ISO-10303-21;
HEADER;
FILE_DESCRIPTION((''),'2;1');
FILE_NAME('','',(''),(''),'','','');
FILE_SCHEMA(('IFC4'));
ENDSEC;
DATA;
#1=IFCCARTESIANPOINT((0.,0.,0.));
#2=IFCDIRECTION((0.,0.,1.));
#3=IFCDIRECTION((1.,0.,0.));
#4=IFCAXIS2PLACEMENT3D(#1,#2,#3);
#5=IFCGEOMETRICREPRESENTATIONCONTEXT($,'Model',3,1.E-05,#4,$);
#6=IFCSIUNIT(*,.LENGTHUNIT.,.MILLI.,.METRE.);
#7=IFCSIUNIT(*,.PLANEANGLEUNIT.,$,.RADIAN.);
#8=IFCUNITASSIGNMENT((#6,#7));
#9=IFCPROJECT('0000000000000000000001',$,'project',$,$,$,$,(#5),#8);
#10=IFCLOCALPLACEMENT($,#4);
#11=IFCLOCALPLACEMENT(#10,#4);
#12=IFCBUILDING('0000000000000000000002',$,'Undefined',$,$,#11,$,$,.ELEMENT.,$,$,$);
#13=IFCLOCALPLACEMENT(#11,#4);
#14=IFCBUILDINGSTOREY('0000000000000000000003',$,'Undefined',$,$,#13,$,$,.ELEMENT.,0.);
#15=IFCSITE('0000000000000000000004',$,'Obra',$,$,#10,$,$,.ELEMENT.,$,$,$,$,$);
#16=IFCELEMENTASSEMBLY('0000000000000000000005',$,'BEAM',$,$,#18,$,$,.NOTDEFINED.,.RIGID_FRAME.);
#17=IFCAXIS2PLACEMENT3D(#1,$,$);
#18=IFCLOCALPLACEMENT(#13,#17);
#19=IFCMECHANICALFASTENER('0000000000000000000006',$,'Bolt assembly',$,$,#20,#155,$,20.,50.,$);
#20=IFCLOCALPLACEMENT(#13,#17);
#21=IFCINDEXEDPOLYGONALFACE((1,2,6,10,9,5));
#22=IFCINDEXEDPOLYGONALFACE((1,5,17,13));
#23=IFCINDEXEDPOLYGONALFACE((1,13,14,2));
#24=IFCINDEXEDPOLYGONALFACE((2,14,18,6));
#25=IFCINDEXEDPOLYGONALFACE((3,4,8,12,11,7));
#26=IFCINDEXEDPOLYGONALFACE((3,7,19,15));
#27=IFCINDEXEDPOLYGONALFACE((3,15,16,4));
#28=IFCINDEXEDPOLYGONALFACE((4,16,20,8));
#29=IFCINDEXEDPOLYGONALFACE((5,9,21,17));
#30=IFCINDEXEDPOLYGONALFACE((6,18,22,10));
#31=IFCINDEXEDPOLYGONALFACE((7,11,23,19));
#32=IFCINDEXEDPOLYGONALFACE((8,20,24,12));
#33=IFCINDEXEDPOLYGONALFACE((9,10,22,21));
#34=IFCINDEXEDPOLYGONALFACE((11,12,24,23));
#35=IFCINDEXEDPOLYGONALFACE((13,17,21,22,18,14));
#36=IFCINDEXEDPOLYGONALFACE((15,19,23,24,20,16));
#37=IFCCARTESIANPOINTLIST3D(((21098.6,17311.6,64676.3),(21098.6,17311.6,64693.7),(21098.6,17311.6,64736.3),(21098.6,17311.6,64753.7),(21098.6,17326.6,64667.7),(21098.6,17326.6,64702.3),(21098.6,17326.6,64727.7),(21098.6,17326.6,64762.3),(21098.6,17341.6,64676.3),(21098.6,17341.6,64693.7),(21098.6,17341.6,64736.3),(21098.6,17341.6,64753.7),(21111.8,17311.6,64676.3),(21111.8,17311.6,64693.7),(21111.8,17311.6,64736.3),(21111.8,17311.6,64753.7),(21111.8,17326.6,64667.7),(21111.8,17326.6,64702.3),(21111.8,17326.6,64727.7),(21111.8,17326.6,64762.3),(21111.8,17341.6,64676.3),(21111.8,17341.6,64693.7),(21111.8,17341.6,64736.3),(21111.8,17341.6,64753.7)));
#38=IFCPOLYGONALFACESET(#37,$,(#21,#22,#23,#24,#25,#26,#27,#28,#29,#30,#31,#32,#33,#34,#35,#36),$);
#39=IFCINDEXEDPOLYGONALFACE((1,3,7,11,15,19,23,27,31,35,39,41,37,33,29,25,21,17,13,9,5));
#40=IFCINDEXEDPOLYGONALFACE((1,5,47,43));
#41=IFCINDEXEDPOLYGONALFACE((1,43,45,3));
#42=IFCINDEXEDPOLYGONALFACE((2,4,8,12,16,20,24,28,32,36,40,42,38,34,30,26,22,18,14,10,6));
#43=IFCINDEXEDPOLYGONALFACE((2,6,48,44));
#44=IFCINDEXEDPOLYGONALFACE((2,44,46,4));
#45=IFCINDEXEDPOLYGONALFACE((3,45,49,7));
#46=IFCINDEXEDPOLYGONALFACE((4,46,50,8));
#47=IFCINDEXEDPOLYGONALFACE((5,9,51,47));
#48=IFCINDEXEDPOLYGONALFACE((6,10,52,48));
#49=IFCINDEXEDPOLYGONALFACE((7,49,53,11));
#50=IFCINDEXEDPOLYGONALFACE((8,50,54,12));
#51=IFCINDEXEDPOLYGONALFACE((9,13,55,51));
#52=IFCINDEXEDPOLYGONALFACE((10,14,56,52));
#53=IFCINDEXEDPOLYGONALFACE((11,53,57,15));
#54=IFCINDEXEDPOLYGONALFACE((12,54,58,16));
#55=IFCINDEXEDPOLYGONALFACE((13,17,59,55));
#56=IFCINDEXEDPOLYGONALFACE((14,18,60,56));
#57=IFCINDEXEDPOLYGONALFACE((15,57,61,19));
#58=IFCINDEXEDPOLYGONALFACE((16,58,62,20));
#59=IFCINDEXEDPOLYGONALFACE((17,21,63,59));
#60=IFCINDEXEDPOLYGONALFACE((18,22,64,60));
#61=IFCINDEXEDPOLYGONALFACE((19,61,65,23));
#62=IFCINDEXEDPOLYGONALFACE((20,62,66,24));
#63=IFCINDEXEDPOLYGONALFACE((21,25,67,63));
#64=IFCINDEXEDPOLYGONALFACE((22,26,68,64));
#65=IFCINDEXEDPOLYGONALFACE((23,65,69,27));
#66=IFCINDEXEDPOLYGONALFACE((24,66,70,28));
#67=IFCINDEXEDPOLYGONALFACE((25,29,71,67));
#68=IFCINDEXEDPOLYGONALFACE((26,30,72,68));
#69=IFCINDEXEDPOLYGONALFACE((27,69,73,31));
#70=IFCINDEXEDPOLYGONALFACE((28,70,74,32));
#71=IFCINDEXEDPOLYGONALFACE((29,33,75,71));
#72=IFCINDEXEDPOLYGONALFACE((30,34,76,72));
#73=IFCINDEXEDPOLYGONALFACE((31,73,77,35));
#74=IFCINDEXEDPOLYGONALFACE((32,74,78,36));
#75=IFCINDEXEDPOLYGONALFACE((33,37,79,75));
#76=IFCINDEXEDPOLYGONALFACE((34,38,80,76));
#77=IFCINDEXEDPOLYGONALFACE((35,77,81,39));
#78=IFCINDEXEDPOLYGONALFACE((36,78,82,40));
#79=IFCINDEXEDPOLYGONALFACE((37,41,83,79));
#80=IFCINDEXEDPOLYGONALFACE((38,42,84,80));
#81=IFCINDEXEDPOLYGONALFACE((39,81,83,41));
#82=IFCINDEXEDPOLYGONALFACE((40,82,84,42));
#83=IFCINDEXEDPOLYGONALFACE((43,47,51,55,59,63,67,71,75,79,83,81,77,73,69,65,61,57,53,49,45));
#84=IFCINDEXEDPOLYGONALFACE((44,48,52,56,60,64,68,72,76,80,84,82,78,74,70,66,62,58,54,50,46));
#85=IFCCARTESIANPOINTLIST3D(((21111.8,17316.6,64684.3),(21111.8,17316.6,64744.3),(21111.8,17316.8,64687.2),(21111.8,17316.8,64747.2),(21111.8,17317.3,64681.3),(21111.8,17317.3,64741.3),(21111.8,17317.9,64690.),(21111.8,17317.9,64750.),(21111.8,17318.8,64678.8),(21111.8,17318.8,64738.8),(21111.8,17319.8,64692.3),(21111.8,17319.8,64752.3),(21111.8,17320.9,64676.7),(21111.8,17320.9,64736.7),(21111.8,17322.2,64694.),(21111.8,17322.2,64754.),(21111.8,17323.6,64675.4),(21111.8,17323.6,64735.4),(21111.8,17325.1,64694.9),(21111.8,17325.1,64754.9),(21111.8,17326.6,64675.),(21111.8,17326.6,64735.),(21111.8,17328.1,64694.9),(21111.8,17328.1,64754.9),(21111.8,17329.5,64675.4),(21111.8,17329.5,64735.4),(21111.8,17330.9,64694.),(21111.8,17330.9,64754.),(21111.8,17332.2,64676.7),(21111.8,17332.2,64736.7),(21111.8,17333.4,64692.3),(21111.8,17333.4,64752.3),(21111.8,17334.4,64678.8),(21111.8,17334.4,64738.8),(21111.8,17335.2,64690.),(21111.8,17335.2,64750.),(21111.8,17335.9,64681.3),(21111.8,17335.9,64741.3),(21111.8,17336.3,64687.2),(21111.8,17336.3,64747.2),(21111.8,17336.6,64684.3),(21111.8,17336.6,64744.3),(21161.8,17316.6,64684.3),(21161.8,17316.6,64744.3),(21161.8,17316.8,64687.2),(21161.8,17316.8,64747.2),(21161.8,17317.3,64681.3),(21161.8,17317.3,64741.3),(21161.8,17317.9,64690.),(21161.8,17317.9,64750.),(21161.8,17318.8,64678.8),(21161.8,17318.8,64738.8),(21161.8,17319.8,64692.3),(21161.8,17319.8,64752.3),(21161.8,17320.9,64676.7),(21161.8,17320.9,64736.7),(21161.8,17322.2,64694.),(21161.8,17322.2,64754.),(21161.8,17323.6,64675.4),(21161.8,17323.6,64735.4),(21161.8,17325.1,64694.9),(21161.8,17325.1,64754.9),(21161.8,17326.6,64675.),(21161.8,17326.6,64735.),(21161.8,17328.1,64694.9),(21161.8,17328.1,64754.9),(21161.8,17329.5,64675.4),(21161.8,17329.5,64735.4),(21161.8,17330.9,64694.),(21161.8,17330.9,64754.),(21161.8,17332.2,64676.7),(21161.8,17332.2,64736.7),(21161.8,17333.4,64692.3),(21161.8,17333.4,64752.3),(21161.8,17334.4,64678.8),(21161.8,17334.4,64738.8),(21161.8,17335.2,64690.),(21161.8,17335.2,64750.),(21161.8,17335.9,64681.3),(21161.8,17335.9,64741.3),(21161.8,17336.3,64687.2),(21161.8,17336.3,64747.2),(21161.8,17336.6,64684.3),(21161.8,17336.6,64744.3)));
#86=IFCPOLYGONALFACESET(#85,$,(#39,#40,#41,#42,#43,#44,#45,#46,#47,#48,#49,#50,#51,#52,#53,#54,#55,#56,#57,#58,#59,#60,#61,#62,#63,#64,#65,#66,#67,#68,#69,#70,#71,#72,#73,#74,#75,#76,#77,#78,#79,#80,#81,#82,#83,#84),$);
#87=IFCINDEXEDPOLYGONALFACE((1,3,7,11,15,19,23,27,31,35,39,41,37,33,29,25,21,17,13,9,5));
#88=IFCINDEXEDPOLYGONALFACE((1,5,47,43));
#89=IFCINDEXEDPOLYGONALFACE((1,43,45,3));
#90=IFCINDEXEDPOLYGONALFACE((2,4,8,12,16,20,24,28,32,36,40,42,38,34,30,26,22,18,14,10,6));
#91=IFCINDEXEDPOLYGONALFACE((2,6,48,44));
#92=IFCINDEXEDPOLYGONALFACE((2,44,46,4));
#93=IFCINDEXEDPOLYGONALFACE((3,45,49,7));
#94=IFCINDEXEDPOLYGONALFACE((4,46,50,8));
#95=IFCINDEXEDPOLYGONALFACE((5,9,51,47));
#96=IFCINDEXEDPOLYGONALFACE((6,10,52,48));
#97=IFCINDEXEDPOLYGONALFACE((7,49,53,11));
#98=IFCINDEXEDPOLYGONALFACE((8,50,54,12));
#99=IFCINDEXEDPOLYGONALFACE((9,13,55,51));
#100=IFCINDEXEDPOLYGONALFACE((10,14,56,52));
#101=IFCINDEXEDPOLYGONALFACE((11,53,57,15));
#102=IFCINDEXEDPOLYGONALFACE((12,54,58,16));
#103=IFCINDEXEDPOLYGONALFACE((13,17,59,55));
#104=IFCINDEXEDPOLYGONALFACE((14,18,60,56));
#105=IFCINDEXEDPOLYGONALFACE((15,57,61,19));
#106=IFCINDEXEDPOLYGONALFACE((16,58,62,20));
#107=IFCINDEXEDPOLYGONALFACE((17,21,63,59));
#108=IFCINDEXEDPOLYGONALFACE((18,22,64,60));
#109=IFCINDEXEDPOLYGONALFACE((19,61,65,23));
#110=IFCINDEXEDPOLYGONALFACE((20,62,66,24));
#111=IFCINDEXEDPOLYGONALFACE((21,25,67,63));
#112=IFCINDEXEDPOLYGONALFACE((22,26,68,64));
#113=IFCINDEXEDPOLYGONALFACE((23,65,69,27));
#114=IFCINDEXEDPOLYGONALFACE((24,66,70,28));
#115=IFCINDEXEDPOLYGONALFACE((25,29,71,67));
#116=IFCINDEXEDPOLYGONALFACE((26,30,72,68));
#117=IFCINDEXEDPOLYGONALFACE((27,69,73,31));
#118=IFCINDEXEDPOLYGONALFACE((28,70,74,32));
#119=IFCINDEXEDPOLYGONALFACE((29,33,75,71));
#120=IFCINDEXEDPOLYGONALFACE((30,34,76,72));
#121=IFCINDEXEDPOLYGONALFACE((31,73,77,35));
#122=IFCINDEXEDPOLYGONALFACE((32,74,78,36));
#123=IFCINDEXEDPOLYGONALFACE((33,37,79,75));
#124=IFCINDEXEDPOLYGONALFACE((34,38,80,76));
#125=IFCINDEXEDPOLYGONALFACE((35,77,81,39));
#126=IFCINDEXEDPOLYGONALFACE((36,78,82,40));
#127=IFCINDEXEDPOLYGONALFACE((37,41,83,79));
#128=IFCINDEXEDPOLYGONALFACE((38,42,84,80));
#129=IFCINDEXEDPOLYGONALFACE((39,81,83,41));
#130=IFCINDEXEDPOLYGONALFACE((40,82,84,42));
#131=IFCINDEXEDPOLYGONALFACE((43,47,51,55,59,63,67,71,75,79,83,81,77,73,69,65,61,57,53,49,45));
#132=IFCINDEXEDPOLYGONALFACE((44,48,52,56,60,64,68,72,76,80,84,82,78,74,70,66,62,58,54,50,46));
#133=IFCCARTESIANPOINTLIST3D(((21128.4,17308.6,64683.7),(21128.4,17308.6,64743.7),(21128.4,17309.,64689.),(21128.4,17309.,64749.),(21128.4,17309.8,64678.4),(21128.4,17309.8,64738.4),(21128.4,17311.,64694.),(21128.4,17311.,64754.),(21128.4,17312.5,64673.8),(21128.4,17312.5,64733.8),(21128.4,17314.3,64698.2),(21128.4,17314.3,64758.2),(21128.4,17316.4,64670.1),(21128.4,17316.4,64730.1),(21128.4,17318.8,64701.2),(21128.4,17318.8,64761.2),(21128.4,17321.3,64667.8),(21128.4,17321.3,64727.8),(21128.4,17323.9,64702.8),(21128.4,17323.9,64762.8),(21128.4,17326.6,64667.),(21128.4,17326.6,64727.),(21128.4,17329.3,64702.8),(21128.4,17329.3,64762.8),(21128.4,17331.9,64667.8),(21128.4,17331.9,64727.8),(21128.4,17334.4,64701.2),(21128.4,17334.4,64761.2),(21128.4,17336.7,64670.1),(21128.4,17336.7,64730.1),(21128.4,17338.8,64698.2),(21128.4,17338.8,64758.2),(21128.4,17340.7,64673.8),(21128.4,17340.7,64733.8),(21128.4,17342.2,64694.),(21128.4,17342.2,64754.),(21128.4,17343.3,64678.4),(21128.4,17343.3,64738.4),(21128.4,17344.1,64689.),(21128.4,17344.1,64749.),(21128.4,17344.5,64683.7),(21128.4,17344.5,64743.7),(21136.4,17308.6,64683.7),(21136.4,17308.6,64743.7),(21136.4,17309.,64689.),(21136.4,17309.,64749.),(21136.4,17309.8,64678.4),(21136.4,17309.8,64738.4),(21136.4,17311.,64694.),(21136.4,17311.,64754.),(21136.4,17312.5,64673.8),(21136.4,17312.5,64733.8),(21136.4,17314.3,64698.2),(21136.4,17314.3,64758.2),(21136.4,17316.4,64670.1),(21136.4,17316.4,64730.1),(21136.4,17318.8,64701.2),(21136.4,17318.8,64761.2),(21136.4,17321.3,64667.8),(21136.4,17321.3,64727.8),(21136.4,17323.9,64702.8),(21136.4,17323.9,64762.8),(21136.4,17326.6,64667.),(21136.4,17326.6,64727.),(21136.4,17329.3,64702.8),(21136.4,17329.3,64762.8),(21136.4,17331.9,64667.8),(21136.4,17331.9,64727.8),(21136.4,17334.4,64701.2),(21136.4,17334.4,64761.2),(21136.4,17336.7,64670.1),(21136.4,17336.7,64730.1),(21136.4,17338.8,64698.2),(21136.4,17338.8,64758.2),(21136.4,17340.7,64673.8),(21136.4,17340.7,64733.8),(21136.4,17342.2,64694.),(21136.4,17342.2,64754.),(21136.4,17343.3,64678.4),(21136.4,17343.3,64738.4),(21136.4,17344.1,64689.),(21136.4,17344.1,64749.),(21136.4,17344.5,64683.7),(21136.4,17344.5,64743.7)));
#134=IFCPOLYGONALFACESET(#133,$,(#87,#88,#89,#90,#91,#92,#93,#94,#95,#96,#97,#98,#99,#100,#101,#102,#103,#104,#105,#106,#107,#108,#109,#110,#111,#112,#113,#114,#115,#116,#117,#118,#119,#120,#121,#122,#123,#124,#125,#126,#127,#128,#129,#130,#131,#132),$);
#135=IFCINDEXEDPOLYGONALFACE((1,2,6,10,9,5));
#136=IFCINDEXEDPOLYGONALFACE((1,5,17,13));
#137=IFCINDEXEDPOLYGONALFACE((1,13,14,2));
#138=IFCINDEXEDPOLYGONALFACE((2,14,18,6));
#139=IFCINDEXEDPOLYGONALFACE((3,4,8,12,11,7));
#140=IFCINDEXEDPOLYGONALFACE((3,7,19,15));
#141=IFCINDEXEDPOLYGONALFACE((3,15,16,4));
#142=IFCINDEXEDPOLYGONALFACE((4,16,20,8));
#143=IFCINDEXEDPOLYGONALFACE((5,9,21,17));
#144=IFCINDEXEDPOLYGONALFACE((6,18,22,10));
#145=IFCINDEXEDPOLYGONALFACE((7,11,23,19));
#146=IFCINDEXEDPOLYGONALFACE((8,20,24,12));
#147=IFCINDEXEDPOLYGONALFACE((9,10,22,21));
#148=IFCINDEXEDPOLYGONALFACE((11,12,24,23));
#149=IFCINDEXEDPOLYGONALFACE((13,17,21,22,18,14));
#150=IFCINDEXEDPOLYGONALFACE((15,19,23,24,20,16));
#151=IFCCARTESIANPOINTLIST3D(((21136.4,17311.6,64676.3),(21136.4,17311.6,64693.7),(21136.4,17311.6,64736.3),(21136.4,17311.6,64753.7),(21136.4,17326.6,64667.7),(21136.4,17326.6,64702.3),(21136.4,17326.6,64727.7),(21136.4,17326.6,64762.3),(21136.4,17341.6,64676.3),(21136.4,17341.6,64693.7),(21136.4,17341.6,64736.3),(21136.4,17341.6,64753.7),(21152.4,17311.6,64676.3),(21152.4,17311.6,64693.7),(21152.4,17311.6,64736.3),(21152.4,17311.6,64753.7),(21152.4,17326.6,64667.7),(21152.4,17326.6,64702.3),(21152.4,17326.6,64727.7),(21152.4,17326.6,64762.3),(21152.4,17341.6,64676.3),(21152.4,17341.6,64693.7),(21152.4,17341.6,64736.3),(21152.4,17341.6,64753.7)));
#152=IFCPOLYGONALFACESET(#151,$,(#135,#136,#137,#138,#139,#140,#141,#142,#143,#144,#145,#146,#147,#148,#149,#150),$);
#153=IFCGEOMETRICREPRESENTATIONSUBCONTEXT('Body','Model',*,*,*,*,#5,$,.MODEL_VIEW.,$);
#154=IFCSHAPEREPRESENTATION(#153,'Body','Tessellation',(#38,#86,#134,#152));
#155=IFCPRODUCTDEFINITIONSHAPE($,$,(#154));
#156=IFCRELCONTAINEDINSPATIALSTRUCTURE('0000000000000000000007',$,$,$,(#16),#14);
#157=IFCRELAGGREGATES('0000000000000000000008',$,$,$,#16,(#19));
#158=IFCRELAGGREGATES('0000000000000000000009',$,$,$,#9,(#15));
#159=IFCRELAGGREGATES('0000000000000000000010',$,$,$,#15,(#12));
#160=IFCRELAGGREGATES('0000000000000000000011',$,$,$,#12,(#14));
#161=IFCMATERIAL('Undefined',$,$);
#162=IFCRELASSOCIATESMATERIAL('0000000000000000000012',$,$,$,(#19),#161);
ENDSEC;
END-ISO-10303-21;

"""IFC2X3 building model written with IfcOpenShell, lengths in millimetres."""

from ifc_helpers import new_model, si_unit, frame, origin_with_axes, origin_2d_with_axis, place, context, subcontext, project, spatial, polyline, circle, outline, extrude, source, transform, mapped, material, element, aggregate, save


model = new_model("IFC2X3")

# Units and contexts
model_context = context("Model", 3, precision=1e-05, world=origin_with_axes())
body_context = subcontext(model_context, "Body", "Model", "MODEL_VIEW")
ifc_project = project(units=[si_unit("LENGTHUNIT", "METRE", prefix="MILLI"), si_unit("PLANEANGLEUNIT", "RADIAN")], contexts=[model_context])

# Site, building, storey
site_placement = place(None, origin_with_axes())
site = spatial("IfcSite", under=ifc_project, at=site_placement, Name="Obra", CompositionType="ELEMENT")
building_placement = place(site_placement, origin_with_axes())
building = spatial("IfcBuilding", under=site, at=building_placement, Name="Undefined", CompositionType="ELEMENT")
storey_placement = place(building_placement, origin_with_axes())
storey = spatial("IfcBuildingStorey", under=building, at=storey_placement, Name="Undefined", CompositionType="ELEMENT", Elevation=0.0)

# Shared definitions
ifc_material = material(Name="Undefined")
shared_shape_1 = source(origin_with_axes(), body_context, "Body", "SweptSolid", [
    extrude(outline(polyline([(17.3, 0.0), (8.7, 15.0), (-8.7, 15.0), (-17.3, 0.0), (-8.7, -15.0), (8.7, -15.0), (17.3, 0.0)])), frame((0.0, -26.5, 0.0), z_axis=(0.0, 1.0, 0.0), x_axis=(1.0, 0.0, 0.0)), (0.0, 0.0, 1.0), 13.2),
    extrude(circle(Radius=10.0, at=origin_2d_with_axis()), frame((0.0, -13.3, 0.0), z_axis=(0.0, 1.0, 0.0), x_axis=(1.0, 0.0, 0.0)), (0.0, 0.0, 1.0), 50.0),
    extrude(circle(Radius=18.0, at=origin_2d_with_axis()), frame((0.0, 3.3, 0.0), z_axis=(0.0, 1.0, 0.0), x_axis=(1.0, 0.0, 0.0)), (0.0, 0.0, 1.0), 8.0),
    extrude(outline(polyline([(17.3, 0.0), (8.7, 15.0), (-8.7, 15.0), (-17.3, 0.0), (-8.7, -15.0), (8.7, -15.0), (17.3, 0.0)])), frame((0.0, 11.3, 0.0), z_axis=(0.0, 1.0, 0.0), x_axis=(1.0, 0.0, 0.0)), (0.0, 0.0, 1.0), 16.0),
])

# Element assembly, mechanical fastener
assembly_1_placement = place(storey_placement, origin_with_axes())
assembly_1 = element("IfcElementAssembly", 1, at=assembly_1_placement, inside=storey, Name="BEAM", AssemblyPlace="NOTDEFINED", PredefinedType="RIGID_FRAME")
mechanical_fastener_1_placement = place(assembly_1_placement, frame((21125.1, 17366.6, 64850.0), z_axis=(0.0, -1.0, 0.0), x_axis=(0.0, 0.0, -1.0)))
mechanical_fastener_1 = element("IfcMechanicalFastener", 2, at=mechanical_fastener_1_placement, material=ifc_material, Name="Bolt assembly", NominalDiameter=20.0, NominalLength=50.0, context=body_context, shape_type="MappedRepresentation", body=[
    mapped(shared_shape_1, transform((105.0, 0.0, 40.0))),
    mapped(shared_shape_1, transform((165.0, 0.0, 40.0))),
])

aggregate(assembly_1, [mechanical_fastener_1])

save(model, "model.ifc")
